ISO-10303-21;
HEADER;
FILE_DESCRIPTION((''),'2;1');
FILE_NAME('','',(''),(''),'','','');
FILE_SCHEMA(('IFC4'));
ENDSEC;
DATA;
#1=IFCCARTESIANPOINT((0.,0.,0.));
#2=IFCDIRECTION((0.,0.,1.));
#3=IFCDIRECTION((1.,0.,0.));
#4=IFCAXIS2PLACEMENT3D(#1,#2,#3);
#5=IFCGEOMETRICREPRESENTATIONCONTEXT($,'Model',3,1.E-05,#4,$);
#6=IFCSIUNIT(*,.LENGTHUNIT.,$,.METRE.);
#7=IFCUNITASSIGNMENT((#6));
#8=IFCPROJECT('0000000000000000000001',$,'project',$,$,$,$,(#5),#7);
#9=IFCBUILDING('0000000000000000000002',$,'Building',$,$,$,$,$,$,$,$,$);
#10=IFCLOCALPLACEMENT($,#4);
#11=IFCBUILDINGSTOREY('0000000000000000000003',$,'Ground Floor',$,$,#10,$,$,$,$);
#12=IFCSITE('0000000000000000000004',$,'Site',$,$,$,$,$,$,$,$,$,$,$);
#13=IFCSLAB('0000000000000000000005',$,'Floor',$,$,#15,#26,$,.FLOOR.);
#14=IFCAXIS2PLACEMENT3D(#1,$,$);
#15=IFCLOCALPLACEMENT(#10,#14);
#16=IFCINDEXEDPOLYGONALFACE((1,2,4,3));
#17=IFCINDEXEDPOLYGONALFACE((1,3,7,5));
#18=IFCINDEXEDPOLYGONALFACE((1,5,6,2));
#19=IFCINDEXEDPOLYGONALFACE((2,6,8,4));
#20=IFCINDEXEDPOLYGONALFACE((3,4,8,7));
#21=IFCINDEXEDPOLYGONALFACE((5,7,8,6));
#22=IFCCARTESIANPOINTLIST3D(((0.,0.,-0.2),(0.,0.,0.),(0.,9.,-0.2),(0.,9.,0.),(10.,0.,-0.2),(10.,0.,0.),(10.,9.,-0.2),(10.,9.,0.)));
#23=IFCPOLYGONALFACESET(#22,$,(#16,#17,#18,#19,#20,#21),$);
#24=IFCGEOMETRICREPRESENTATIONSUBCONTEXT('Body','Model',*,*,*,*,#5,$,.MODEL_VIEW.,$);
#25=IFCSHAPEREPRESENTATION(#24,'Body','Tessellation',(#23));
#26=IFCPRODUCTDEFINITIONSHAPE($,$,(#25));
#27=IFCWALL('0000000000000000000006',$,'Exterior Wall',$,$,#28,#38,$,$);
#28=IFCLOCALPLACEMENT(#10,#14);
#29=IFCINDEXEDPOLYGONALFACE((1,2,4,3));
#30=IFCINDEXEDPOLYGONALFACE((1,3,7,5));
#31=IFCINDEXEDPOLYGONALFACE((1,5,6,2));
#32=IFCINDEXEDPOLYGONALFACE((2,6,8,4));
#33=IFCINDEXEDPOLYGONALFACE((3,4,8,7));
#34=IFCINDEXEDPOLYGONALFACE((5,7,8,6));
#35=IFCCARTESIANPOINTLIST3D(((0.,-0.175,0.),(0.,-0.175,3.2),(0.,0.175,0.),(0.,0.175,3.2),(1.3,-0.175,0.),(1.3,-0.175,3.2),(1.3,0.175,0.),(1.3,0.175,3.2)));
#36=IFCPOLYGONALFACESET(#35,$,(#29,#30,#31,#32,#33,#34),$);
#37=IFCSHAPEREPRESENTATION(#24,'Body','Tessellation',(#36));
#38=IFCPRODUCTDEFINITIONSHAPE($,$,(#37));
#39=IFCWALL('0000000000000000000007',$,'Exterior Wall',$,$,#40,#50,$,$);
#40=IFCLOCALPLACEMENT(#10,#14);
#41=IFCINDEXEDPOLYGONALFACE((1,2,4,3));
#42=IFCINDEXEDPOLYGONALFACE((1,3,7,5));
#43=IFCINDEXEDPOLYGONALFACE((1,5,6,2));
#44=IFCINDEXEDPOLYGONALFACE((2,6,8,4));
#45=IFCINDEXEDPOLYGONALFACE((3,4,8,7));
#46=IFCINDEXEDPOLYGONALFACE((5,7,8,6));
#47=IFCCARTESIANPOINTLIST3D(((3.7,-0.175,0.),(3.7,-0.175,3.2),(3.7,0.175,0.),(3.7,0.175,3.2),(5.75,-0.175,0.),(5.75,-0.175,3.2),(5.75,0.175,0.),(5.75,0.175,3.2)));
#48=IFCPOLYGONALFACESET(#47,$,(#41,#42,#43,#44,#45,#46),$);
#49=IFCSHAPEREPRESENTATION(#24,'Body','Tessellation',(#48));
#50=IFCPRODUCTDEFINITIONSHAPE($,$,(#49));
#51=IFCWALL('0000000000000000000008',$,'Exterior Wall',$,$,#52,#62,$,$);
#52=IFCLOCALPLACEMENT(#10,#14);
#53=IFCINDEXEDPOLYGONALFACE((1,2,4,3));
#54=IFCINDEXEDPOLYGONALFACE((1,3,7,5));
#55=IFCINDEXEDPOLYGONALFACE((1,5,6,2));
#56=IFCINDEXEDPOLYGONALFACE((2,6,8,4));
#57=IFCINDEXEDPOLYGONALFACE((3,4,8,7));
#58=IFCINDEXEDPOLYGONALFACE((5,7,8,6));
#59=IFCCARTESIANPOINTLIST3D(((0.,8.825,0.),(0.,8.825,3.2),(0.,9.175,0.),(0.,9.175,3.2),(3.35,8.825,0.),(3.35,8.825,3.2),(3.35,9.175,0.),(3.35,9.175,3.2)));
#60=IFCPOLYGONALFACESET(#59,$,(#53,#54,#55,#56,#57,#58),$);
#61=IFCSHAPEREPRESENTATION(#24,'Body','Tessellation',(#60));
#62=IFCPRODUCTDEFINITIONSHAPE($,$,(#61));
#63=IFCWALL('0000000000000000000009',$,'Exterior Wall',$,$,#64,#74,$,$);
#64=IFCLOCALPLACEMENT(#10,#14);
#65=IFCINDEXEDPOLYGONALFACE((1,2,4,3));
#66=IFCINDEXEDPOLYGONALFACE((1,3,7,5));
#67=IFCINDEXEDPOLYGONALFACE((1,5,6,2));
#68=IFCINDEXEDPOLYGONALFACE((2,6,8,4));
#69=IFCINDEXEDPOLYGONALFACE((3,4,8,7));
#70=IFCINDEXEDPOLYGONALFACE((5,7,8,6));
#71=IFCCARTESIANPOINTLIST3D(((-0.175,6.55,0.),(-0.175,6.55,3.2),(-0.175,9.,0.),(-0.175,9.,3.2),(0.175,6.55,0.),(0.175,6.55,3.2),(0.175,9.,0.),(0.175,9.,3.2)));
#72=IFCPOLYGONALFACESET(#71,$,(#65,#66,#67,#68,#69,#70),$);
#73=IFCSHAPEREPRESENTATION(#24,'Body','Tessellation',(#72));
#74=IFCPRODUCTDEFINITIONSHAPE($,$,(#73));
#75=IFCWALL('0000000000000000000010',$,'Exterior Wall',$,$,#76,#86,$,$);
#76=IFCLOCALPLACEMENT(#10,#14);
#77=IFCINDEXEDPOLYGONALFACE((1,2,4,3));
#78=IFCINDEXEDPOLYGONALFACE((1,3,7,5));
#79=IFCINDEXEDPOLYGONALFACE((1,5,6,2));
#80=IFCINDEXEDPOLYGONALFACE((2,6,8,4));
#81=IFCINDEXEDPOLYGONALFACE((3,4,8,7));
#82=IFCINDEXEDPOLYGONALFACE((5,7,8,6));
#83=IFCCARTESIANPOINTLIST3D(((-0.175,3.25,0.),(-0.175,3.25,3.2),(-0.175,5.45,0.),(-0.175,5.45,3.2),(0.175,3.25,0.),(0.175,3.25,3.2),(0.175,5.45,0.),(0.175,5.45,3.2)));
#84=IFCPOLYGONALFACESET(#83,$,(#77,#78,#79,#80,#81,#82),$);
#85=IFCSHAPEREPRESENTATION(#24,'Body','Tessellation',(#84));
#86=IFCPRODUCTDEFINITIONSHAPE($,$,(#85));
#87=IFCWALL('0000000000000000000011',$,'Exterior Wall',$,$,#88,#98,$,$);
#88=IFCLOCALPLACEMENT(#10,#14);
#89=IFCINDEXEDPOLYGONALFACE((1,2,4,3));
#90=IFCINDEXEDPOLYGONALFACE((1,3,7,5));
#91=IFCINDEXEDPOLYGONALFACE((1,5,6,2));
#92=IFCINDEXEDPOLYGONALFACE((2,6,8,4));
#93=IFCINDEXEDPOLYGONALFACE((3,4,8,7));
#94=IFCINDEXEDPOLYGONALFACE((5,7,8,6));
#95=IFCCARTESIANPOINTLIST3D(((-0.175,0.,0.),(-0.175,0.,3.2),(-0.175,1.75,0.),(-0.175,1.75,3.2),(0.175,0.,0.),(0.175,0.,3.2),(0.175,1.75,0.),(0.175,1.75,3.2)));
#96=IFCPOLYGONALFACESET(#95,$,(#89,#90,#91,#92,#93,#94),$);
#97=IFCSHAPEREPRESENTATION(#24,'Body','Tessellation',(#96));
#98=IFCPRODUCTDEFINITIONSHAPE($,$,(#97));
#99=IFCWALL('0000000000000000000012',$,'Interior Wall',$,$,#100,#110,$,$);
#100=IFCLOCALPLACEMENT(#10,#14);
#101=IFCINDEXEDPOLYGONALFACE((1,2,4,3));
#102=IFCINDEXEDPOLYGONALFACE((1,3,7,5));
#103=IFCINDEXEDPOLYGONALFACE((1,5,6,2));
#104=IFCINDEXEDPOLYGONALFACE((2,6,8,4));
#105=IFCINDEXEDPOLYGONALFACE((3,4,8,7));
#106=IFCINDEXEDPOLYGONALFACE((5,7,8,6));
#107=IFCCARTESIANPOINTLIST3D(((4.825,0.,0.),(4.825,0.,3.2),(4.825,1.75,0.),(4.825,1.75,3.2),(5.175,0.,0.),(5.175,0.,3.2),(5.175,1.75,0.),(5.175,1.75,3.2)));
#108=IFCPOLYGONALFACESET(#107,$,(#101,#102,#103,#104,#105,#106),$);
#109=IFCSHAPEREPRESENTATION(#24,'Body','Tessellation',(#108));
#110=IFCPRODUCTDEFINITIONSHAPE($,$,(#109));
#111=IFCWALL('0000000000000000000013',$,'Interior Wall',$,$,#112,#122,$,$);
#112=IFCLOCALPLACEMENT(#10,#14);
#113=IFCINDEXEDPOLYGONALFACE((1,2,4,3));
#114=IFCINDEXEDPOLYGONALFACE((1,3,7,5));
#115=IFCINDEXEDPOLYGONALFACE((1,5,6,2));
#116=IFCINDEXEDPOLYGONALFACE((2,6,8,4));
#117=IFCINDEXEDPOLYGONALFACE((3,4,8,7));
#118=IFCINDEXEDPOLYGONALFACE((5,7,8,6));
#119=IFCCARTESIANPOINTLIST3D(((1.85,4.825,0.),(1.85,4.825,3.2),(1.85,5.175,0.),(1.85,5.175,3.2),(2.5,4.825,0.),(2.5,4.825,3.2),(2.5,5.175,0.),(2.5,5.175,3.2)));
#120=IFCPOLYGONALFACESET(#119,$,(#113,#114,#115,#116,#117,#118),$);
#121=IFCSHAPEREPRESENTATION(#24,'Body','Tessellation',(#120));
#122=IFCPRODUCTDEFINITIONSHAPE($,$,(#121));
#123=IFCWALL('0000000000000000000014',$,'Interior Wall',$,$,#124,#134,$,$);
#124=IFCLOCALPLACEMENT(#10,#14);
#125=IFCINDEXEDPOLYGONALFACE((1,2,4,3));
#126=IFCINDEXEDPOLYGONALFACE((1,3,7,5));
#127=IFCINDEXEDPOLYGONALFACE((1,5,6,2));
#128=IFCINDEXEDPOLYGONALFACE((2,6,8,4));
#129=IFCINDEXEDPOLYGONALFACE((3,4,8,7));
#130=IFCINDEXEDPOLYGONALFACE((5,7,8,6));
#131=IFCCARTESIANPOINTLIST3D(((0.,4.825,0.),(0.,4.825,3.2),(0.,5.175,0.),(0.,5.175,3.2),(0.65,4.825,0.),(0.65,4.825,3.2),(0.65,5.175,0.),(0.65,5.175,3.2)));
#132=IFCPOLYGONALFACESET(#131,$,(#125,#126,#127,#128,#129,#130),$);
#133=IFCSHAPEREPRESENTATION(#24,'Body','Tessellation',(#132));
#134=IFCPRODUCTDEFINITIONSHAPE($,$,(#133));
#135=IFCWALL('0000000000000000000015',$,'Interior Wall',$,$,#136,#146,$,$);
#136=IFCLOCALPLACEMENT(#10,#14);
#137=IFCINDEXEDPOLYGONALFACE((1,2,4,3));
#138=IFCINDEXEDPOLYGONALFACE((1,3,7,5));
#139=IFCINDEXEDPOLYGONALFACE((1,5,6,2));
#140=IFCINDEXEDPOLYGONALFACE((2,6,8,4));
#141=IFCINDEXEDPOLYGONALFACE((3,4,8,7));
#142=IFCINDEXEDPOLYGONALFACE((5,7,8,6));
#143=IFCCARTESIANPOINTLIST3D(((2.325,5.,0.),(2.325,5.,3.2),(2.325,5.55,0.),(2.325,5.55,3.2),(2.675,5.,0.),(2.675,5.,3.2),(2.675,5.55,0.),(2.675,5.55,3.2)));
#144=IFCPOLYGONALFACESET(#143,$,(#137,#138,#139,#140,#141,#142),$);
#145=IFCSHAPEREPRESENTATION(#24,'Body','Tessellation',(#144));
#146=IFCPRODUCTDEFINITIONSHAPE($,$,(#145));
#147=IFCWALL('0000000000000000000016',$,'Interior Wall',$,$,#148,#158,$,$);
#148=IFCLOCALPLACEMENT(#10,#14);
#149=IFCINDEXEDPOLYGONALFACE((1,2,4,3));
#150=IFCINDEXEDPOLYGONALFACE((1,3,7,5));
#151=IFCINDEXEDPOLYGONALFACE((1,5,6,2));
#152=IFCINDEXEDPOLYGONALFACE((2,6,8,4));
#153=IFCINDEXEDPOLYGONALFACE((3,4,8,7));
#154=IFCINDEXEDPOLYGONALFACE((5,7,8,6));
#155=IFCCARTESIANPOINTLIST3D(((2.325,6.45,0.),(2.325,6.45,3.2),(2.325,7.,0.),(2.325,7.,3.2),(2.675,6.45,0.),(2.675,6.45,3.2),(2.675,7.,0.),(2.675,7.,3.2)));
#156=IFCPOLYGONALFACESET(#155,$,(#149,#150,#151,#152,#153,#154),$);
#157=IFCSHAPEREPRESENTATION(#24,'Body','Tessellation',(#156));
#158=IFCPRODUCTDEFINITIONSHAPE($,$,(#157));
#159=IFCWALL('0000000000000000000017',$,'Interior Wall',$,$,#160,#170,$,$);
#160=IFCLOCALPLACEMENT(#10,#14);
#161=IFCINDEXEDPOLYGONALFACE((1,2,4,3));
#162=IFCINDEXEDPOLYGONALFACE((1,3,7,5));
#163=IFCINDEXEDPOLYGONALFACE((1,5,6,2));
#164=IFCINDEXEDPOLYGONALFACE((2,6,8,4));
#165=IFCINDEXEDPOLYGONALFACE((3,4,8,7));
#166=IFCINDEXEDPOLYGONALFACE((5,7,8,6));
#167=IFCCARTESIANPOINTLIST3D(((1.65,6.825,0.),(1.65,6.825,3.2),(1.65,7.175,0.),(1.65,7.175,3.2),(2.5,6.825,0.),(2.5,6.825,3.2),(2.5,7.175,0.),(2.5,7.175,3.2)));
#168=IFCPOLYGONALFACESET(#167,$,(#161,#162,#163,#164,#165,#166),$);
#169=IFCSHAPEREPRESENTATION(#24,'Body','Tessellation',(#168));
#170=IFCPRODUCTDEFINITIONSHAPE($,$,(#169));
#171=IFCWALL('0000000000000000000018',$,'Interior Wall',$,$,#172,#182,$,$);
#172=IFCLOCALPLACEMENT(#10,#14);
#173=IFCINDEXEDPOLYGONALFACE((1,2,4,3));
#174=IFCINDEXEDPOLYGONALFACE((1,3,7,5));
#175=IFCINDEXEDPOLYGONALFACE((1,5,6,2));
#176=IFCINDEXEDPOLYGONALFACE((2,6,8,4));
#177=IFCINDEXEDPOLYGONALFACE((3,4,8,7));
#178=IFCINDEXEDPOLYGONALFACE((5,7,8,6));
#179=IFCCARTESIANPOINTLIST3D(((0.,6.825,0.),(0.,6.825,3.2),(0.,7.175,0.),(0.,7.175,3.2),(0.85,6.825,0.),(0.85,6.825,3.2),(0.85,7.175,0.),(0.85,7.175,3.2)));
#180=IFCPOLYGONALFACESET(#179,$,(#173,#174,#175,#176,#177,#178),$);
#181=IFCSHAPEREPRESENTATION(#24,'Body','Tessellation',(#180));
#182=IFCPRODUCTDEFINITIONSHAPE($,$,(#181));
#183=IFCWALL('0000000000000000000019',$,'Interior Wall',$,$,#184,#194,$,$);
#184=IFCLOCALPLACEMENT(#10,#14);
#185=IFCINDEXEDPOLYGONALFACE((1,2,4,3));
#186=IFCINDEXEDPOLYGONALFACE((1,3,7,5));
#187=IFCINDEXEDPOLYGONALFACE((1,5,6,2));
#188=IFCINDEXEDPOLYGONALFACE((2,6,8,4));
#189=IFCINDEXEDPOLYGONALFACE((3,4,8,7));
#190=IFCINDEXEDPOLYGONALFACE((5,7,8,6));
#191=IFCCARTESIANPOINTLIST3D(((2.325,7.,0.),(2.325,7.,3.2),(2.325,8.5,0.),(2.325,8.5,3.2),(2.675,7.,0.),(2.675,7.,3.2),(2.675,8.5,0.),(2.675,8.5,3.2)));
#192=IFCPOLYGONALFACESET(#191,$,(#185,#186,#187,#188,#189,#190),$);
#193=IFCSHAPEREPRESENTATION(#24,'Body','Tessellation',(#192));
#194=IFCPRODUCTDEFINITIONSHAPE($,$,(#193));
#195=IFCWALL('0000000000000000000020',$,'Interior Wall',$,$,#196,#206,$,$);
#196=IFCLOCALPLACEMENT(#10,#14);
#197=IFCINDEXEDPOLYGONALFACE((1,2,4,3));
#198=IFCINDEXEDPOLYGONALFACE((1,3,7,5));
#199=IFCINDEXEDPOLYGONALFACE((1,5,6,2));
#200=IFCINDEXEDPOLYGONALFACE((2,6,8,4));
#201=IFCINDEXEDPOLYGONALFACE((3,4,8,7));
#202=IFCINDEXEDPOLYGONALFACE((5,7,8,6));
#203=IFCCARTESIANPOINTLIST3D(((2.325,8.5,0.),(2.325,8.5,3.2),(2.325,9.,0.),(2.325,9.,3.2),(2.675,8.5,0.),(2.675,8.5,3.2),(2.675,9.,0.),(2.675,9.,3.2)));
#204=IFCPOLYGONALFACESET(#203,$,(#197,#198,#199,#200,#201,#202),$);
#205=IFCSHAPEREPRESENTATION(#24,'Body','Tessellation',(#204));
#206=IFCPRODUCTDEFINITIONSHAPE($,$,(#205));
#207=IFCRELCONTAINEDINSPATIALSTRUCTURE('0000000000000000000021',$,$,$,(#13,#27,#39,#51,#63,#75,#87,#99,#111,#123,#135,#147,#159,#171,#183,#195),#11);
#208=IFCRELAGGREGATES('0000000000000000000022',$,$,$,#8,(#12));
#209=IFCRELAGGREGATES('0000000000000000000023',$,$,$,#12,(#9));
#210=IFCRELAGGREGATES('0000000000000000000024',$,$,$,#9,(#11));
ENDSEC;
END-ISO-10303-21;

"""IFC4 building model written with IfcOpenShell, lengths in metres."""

from ifc_helpers import new_model, si_unit, frame, origin_with_axes, place, context, subcontext, project, spatial, indexed_curve, outline, extrude, element, save


model = new_model("IFC4")

# Units and contexts
model_context = context("Model", 3, precision=1e-05, world=origin_with_axes())
body_context = subcontext(model_context, "Body", "Model", "MODEL_VIEW")
ifc_project = project(units=[si_unit("LENGTHUNIT", "METRE")], contexts=[model_context])

# Site, building, storey
site = spatial("IfcSite", under=ifc_project, Name="Site")
building = spatial("IfcBuilding", under=site, Name="Building")
storey_placement = place(None, origin_with_axes())
storey = spatial("IfcBuildingStorey", under=building, at=storey_placement, Name="Ground Floor")

# Slab
slab_placement = place(storey_placement, frame((0.0, 0.0, -0.2), z_axis=(0.0, 0.0, 1.0), x_axis=(1.0, 0.0, 0.0)))
element("IfcSlab", 1, at=slab_placement, inside=storey, Name="Floor", PredefinedType="FLOOR", context=body_context, shape_type="SweptSolid", body=[
    extrude(outline(indexed_curve([(0.0, 0.0), (10.0, 0.0), (10.0, 9.0), (0.0, 9.0)])), None, (0.0, 0.0, 1.0), 0.2),
])

# Walls
wall_1_placement = place(storey_placement, origin_with_axes())
element("IfcWall", 2, at=wall_1_placement, inside=storey, Name="Exterior Wall", context=body_context, shape_type="SweptSolid", body=[
    extrude(outline(indexed_curve([(0.0, 0.0), (0.0, 0.35), (1.3, 0.35), (1.3, 0.0), (0.0, 0.0)], self_intersect=False)), frame((0.0, -0.175, 0.0), z_axis=(0.0, 0.0, 1.0), x_axis=(1.0, 0.0, 0.0)), (0.0, 0.0, 1.0), 3.2),
])
wall_2_placement = place(storey_placement, frame((3.7, 0.0, 0.0), z_axis=(0.0, 0.0, 1.0), x_axis=(1.0, 0.0, 0.0)))
element("IfcWall", 3, at=wall_2_placement, inside=storey, Name="Exterior Wall", context=body_context, shape_type="SweptSolid", body=[
    extrude(outline(indexed_curve([(0.0, 0.0), (0.0, 0.35), (2.05, 0.35), (2.05, 0.0), (0.0, 0.0)], self_intersect=False)), frame((0.0, -0.175, 0.0), z_axis=(0.0, 0.0, 1.0), x_axis=(1.0, 0.0, 0.0)), (0.0, 0.0, 1.0), 3.2),
])
wall_3_placement = place(storey_placement, frame((3.35, 9.0, 0.0), z_axis=(0.0, 0.0, 1.0), x_axis=(-1.0, 0.0, 0.0)))
element("IfcWall", 4, at=wall_3_placement, inside=storey, Name="Exterior Wall", context=body_context, shape_type="SweptSolid", body=[
    extrude(outline(indexed_curve([(0.0, 0.0), (0.0, 0.35), (3.35, 0.35), (3.35, 0.0), (0.0, 0.0)], self_intersect=False)), frame((0.0, -0.175, 0.0), z_axis=(0.0, 0.0, 1.0), x_axis=(1.0, 0.0, 0.0)), (0.0, 0.0, 1.0), 3.2),
])
wall_4_placement = place(storey_placement, frame((0.0, 9.0, 0.0), z_axis=(0.0, 0.0, 1.0), x_axis=(0.0, -1.0, 0.0)))
element("IfcWall", 5, at=wall_4_placement, inside=storey, Name="Exterior Wall", context=body_context, shape_type="SweptSolid", body=[
    extrude(outline(indexed_curve([(0.0, 0.0), (0.0, 0.35), (2.45, 0.35), (2.45, 0.0), (0.0, 0.0)], self_intersect=False)), frame((0.0, -0.175, 0.0), z_axis=(0.0, 0.0, 1.0), x_axis=(1.0, 0.0, 0.0)), (0.0, 0.0, 1.0), 3.2),
])
wall_5_placement = place(storey_placement, frame((0.0, 5.45, 0.0), z_axis=(0.0, 0.0, 1.0), x_axis=(0.0, -1.0, 0.0)))
element("IfcWall", 6, at=wall_5_placement, inside=storey, Name="Exterior Wall", context=body_context, shape_type="SweptSolid", body=[
    extrude(outline(indexed_curve([(0.0, 0.0), (0.0, 0.35), (2.2, 0.35), (2.2, 0.0), (0.0, 0.0)], self_intersect=False)), frame((0.0, -0.175, 0.0), z_axis=(0.0, 0.0, 1.0), x_axis=(1.0, 0.0, 0.0)), (0.0, 0.0, 1.0), 3.2),
])
for number, where, z_axis, x_axis, name in (
    (7, (0.0, 1.75, 0.0), (0.0, 0.0, 1.0), (0.0, -1.0, 0.0), "Exterior Wall"),
    (8, (5.0, 0.0, 0.0), (0.0, 0.0, 1.0), (0.0, 1.0, 0.0), "Interior Wall"),
):
    element("IfcWall", number, at=place(storey_placement, frame(where, z_axis=z_axis, x_axis=x_axis)), inside=storey, Name=name, context=body_context, shape_type="SweptSolid", body=[
        extrude(outline(indexed_curve([(0.0, 0.0), (0.0, 0.35), (1.75, 0.35), (1.75, 0.0), (0.0, 0.0)], self_intersect=False)), frame((0.0, -0.175, 0.0), z_axis=(0.0, 0.0, 1.0), x_axis=(1.0, 0.0, 0.0)), (0.0, 0.0, 1.0), 3.2),
    ])
for number, where, z_axis, x_axis, name in (
    (9, (2.5, 5.0, 0.0), (0.0, 0.0, 1.0), (-1.0, 0.0, 0.0), "Interior Wall"),
    (10, (0.65, 5.0, 0.0), (0.0, 0.0, 1.0), (-1.0, 0.0, 0.0), "Interior Wall"),
):
    element("IfcWall", number, at=place(storey_placement, frame(where, z_axis=z_axis, x_axis=x_axis)), inside=storey, Name=name, context=body_context, shape_type="SweptSolid", body=[
        extrude(outline(indexed_curve([(0.0, 0.0), (0.0, 0.35), (0.65, 0.35), (0.65, 0.0), (0.0, 0.0)], self_intersect=False)), frame((0.0, -0.175, 0.0), z_axis=(0.0, 0.0, 1.0), x_axis=(1.0, 0.0, 0.0)), (0.0, 0.0, 1.0), 3.2),
    ])
for number, where, z_axis, x_axis, name in (
    (11, (2.5, 5.0, 0.0), (0.0, 0.0, 1.0), (0.0, 1.0, 0.0), "Interior Wall"),
    (12, (2.5, 6.45, 0.0), (0.0, 0.0, 1.0), (0.0, 1.0, 0.0), "Interior Wall"),
):
    element("IfcWall", number, at=place(storey_placement, frame(where, z_axis=z_axis, x_axis=x_axis)), inside=storey, Name=name, context=body_context, shape_type="SweptSolid", body=[
        extrude(outline(indexed_curve([(0.0, 0.0), (0.0, 0.35), (0.55, 0.35), (0.55, 0.0), (0.0, 0.0)], self_intersect=False)), frame((0.0, -0.175, 0.0), z_axis=(0.0, 0.0, 1.0), x_axis=(1.0, 0.0, 0.0)), (0.0, 0.0, 1.0), 3.2),
    ])
for number, where, z_axis, x_axis, name in (
    (13, (2.5, 7.0, 0.0), (0.0, 0.0, 1.0), (-1.0, 0.0, 0.0), "Interior Wall"),
    (14, (0.85, 7.0, 0.0), (0.0, 0.0, 1.0), (-1.0, 0.0, 0.0), "Interior Wall"),
):
    element("IfcWall", number, at=place(storey_placement, frame(where, z_axis=z_axis, x_axis=x_axis)), inside=storey, Name=name, context=body_context, shape_type="SweptSolid", body=[
        extrude(outline(indexed_curve([(0.0, 0.0), (0.0, 0.35), (0.85, 0.35), (0.85, 0.0), (0.0, 0.0)], self_intersect=False)), frame((0.0, -0.175, 0.0), z_axis=(0.0, 0.0, 1.0), x_axis=(1.0, 0.0, 0.0)), (0.0, 0.0, 1.0), 3.2),
    ])
wall_6_placement = place(storey_placement, frame((2.5, 8.5, 0.0), z_axis=(0.0, 0.0, 1.0), x_axis=(0.0, -1.0, 0.0)))
element("IfcWall", 15, at=wall_6_placement, inside=storey, Name="Interior Wall", context=body_context, shape_type="SweptSolid", body=[
    extrude(outline(indexed_curve([(0.0, 0.0), (0.0, 0.35), (1.5, 0.35), (1.5, 0.0), (0.0, 0.0)], self_intersect=False)), frame((0.0, -0.175, 0.0), z_axis=(0.0, 0.0, 1.0), x_axis=(1.0, 0.0, 0.0)), (0.0, 0.0, 1.0), 3.2),
])
wall_7_placement = place(storey_placement, frame((2.5, 9.0, 0.0), z_axis=(0.0, 0.0, 1.0), x_axis=(0.0, -1.0, 0.0)))
element("IfcWall", 16, at=wall_7_placement, inside=storey, Name="Interior Wall", context=body_context, shape_type="SweptSolid", body=[
    extrude(outline(indexed_curve([(0.0, 0.0), (0.0, 0.35), (0.5, 0.35), (0.5, 0.0), (0.0, 0.0)], self_intersect=False)), frame((0.0, -0.175, 0.0), z_axis=(0.0, 0.0, 1.0), x_axis=(1.0, 0.0, 0.0)), (0.0, 0.0, 1.0), 3.2),
])

save(model, "model.ifc")
